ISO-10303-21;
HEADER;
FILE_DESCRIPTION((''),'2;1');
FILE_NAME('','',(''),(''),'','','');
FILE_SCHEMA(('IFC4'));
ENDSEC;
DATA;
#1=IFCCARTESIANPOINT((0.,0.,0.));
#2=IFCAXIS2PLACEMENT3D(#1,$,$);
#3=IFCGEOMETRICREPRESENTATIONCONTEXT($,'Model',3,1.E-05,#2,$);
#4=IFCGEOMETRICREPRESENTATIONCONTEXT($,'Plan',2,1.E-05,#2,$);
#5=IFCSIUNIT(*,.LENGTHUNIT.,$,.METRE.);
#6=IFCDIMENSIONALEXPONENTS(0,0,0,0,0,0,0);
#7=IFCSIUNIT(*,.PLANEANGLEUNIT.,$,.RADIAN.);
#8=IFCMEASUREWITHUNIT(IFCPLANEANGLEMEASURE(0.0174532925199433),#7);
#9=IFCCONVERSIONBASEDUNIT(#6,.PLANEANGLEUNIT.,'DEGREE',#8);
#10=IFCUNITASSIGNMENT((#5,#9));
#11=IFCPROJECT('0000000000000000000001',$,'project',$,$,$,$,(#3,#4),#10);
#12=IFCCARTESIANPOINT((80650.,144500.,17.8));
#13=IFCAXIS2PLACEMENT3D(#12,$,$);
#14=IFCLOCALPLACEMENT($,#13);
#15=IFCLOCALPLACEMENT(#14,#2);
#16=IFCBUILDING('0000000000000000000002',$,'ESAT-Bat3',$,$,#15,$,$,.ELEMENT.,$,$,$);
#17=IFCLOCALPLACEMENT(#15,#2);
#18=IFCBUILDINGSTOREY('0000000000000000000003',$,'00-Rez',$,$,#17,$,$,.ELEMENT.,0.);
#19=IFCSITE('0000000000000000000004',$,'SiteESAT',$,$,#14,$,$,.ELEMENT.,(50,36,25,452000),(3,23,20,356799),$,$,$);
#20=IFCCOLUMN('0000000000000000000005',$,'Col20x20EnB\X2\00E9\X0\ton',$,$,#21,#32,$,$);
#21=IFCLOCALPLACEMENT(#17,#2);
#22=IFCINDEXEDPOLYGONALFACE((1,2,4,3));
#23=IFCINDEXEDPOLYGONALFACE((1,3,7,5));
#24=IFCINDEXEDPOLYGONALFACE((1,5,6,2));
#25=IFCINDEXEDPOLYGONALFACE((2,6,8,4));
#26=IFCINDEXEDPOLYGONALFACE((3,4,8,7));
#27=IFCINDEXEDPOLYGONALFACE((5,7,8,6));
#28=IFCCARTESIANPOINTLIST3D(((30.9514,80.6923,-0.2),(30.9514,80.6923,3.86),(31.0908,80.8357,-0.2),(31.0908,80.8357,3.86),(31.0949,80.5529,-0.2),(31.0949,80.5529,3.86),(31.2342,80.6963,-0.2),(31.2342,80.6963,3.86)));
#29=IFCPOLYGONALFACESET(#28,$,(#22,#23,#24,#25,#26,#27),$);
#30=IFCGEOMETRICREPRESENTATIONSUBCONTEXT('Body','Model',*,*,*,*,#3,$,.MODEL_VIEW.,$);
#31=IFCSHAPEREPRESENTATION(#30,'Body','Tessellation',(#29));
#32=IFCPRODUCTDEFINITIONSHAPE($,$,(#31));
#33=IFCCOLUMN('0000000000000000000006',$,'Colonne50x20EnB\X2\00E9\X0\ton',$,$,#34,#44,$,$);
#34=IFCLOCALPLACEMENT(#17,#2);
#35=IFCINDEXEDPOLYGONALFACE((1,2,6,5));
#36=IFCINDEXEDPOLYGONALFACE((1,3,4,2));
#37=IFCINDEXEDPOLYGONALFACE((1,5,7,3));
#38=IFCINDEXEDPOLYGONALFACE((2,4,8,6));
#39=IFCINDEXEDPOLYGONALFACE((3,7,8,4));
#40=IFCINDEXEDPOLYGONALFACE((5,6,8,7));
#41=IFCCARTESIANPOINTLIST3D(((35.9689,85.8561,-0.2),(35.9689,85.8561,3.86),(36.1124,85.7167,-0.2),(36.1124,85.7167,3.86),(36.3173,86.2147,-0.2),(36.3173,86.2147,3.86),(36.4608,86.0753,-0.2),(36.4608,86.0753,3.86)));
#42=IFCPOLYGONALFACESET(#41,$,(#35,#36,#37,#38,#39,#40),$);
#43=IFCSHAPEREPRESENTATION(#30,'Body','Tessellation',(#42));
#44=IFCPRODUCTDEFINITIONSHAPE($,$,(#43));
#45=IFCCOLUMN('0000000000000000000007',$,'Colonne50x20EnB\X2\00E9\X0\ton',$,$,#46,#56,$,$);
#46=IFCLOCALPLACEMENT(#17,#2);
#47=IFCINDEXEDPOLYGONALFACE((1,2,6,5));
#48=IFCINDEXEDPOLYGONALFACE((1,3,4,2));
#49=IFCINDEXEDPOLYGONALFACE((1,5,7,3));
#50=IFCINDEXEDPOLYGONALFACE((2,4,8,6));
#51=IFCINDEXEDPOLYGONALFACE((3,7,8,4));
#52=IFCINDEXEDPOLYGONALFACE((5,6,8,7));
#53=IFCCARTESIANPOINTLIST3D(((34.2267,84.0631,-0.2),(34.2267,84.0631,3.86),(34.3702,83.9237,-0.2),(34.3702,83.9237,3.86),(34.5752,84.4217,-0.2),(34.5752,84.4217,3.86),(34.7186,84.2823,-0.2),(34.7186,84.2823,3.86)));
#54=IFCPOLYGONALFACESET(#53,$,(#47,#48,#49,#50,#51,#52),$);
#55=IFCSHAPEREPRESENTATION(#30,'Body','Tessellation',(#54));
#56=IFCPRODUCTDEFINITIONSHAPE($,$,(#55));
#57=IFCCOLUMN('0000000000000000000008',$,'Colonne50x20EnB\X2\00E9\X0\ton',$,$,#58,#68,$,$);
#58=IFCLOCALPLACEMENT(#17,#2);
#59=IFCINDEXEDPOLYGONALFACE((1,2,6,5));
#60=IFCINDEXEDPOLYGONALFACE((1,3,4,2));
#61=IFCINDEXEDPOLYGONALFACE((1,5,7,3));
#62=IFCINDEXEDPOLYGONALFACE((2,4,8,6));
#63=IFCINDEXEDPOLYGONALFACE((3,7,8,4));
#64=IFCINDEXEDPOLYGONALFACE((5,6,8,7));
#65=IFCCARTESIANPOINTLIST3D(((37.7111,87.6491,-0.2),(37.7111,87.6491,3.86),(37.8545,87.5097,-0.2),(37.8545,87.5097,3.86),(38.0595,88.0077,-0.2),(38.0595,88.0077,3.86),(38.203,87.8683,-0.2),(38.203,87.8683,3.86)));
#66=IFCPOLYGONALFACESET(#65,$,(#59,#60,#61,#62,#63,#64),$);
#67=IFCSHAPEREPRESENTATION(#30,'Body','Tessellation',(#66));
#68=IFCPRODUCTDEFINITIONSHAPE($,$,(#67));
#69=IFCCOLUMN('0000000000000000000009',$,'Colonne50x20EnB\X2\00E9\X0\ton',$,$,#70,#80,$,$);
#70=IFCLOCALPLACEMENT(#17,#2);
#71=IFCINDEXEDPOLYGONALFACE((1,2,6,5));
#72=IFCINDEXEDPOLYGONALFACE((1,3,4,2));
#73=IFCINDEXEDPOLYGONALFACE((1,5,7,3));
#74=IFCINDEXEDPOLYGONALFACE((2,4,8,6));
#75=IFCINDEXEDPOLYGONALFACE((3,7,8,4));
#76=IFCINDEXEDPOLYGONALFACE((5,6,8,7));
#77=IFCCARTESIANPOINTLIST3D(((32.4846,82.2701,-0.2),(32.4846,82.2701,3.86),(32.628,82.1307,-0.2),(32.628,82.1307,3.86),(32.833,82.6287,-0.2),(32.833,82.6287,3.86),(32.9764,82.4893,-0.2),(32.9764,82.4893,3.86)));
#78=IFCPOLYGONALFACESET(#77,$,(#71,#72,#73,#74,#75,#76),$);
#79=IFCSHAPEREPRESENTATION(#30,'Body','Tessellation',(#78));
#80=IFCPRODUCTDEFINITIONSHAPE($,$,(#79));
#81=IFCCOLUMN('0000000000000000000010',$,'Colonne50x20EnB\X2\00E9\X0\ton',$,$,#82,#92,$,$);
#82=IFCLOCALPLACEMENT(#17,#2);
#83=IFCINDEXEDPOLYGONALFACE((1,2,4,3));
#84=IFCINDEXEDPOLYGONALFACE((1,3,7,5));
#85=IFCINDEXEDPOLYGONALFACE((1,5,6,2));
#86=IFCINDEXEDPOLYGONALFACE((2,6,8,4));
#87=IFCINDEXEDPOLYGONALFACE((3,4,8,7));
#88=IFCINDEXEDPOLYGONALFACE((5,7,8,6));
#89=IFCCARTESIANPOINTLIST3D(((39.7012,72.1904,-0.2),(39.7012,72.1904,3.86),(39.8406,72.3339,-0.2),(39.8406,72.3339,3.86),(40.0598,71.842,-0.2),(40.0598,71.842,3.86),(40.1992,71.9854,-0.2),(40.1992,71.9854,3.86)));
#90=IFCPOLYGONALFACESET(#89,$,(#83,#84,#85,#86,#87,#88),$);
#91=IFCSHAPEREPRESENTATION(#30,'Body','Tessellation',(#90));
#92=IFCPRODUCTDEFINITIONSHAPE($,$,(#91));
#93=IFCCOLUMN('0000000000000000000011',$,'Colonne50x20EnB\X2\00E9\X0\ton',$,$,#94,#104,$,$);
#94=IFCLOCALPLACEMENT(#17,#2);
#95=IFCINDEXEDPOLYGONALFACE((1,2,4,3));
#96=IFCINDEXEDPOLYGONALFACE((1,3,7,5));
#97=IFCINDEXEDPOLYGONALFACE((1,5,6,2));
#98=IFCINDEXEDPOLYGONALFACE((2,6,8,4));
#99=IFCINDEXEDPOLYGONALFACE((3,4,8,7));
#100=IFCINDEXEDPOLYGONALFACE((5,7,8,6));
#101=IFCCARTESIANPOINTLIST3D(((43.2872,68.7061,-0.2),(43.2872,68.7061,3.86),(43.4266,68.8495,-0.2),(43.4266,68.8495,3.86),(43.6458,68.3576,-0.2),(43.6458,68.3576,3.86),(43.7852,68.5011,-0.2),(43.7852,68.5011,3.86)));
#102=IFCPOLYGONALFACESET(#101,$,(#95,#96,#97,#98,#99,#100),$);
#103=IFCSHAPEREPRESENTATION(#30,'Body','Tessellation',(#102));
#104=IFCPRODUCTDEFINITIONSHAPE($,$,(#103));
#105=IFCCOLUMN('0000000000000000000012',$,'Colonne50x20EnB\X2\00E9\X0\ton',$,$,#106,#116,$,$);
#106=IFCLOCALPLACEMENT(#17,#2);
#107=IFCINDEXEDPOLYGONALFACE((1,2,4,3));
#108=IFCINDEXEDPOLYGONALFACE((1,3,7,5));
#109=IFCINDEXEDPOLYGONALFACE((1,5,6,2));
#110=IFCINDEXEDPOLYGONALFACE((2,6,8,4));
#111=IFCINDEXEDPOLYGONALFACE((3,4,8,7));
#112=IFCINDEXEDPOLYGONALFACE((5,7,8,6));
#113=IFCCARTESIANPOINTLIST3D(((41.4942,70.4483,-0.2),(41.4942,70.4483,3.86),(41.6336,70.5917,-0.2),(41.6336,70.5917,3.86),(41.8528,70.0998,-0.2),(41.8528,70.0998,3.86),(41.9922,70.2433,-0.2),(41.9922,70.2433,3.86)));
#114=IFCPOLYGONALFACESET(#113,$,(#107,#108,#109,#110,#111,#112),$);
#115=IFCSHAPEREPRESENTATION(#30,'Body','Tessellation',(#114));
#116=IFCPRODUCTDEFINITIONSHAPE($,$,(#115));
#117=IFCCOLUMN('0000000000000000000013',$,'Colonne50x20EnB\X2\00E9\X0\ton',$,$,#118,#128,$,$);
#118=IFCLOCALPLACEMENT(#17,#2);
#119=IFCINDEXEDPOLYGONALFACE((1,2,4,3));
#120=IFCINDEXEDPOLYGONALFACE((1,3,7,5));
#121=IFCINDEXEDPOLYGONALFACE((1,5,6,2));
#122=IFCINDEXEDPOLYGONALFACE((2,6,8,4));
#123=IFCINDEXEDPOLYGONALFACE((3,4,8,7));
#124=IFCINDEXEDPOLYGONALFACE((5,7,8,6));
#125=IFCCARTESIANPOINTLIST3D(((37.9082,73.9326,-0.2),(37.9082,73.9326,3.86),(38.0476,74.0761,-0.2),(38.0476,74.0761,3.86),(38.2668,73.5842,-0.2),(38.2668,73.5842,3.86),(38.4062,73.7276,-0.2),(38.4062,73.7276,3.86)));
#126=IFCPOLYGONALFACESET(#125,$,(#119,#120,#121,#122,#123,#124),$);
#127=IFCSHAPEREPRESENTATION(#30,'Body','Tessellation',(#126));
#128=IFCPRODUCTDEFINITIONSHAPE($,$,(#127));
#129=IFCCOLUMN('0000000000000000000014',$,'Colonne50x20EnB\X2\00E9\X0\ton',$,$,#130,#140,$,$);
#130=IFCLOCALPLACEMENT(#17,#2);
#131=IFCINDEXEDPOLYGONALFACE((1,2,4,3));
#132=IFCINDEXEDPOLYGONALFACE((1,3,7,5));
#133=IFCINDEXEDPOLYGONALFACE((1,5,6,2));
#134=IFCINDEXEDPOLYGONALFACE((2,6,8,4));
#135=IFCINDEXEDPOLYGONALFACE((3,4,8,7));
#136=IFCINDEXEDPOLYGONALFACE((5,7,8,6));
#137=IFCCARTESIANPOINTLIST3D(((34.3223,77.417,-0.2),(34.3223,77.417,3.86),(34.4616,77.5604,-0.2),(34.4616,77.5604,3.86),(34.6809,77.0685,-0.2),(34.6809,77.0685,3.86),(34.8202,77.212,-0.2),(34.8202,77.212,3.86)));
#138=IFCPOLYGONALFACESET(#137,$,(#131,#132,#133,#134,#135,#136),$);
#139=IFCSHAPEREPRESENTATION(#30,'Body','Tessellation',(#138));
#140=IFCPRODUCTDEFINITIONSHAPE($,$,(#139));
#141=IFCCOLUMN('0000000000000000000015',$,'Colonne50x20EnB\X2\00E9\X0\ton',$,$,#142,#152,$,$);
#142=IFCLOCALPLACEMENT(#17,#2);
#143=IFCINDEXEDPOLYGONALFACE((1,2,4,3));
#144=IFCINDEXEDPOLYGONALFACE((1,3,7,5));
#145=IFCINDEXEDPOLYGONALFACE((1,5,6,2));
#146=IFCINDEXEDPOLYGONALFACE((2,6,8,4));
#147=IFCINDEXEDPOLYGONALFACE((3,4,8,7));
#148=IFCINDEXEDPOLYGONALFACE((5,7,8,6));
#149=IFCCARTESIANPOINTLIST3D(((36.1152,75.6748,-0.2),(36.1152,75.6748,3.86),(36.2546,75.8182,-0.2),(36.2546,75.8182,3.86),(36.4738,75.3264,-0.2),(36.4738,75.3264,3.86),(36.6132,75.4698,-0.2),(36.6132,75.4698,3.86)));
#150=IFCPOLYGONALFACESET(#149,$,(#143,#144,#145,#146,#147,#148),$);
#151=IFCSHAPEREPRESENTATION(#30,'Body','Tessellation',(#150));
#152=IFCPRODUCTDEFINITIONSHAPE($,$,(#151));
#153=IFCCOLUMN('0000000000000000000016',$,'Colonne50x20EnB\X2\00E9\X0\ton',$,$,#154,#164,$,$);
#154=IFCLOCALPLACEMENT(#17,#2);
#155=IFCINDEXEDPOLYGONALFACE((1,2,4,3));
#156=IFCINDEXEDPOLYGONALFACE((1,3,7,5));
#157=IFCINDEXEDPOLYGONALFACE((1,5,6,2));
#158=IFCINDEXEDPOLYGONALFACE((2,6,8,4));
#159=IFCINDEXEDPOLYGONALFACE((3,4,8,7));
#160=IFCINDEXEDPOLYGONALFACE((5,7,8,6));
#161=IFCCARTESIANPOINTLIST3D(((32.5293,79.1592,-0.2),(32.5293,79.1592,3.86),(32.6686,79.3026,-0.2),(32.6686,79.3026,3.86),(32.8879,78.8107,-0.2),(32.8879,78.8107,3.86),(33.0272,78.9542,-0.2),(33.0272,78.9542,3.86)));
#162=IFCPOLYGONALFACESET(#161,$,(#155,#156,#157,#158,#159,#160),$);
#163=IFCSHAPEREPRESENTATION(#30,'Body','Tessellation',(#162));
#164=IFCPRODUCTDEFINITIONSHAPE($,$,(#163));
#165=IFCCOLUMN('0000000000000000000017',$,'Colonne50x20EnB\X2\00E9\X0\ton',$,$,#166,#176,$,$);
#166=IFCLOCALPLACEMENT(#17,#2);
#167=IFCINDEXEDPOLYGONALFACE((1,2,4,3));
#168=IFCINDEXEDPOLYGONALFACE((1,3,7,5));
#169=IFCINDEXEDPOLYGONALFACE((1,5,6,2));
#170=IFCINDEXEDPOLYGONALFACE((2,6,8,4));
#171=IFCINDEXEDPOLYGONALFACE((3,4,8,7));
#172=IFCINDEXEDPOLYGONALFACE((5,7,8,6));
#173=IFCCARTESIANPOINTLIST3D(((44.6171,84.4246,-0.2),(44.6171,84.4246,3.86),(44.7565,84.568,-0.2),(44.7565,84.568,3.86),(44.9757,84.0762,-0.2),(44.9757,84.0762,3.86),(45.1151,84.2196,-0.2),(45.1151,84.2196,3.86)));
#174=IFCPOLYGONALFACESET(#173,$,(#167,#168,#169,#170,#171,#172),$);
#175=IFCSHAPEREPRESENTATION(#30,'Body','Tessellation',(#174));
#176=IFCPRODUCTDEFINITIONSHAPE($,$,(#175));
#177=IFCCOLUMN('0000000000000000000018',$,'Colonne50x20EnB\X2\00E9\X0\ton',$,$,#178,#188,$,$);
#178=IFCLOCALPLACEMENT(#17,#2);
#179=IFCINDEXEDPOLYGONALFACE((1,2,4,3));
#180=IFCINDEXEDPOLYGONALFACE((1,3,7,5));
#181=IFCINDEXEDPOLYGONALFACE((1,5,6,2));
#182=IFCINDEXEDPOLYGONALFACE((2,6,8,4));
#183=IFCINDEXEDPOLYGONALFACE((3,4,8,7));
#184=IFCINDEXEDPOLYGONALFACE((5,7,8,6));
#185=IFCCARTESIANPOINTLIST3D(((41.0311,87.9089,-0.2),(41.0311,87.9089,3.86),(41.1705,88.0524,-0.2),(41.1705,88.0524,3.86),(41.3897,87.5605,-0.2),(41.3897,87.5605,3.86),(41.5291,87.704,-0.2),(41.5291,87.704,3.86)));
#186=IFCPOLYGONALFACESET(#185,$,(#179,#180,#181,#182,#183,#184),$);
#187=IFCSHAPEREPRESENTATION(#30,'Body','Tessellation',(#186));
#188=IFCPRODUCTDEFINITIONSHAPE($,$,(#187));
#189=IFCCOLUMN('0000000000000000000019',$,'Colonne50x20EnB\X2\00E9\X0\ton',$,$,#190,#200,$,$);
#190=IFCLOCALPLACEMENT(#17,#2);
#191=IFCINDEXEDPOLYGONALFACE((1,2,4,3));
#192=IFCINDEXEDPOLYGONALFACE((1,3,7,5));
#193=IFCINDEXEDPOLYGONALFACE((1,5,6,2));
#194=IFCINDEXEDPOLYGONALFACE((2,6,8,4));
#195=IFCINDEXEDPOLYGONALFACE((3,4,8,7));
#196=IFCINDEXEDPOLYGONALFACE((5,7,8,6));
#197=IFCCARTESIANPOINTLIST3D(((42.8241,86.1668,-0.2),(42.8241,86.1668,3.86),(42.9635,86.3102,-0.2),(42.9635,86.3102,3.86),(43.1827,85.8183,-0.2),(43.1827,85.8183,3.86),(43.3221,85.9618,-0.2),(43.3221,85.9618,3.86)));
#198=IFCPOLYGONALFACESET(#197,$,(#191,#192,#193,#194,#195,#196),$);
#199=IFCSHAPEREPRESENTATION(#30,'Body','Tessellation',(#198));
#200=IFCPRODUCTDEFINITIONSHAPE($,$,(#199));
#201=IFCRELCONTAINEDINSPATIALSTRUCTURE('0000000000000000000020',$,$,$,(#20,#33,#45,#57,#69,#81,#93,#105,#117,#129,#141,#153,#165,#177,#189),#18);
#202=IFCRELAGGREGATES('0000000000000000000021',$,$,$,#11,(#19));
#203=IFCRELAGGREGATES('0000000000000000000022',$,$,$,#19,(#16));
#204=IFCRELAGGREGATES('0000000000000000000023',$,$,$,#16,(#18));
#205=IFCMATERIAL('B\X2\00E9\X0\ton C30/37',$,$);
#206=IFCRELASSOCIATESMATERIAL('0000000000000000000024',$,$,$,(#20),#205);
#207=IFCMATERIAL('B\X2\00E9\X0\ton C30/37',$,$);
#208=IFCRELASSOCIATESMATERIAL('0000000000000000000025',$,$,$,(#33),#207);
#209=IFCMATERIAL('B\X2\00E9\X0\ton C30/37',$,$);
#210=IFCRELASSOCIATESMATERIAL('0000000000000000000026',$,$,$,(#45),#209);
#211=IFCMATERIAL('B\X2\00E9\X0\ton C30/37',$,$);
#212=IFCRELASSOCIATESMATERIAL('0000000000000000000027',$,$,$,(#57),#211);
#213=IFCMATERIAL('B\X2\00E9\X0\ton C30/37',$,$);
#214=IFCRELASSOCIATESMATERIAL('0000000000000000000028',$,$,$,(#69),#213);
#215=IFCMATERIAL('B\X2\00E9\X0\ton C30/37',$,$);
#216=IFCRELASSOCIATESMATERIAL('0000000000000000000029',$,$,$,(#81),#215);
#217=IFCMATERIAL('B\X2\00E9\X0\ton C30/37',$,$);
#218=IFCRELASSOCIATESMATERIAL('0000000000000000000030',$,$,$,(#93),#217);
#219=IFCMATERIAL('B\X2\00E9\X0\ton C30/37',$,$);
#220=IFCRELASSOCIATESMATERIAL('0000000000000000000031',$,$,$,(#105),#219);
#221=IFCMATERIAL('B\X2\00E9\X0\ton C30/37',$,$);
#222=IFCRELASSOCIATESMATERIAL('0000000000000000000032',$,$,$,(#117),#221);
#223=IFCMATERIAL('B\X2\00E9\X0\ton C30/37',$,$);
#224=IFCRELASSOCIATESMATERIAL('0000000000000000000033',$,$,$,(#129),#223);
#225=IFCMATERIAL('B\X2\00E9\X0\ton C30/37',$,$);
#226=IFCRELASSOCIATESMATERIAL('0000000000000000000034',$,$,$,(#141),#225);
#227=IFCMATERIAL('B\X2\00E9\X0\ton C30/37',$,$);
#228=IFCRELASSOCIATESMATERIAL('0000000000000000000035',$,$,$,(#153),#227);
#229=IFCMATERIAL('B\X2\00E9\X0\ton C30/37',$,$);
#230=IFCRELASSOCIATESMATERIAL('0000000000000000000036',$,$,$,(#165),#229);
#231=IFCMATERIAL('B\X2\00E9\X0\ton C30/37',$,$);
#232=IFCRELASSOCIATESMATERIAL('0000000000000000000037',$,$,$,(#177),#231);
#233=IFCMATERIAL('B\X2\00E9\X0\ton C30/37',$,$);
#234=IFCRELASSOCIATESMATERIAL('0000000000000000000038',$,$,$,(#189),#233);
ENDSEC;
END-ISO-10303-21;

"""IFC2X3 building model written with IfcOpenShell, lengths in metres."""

from ifc_helpers import new_model, entity, si_unit, converted_unit, frame, frame_2d, origin, origin_with_axes, place, context, subcontext, project, spatial, rectangle, extrude, material, element, save


model = new_model("IFC2X3")

# Units and contexts
model_context = context("Model", 3, precision=1e-05, world=origin())
plan_context = context("Plan", 2, precision=1e-05, world=origin())
body_context = subcontext(model_context, "Body", "Model", "MODEL_VIEW")
ifc_project = project(units=[si_unit("LENGTHUNIT", "METRE"), converted_unit("PLANEANGLEUNIT", "DEGREE", entity("IfcPlaneAngleMeasure", 0.0174532925199433), si_unit("PLANEANGLEUNIT", "RADIAN"), dimensions=[0, 0, 0, 0, 0, 0, 0])], contexts=[model_context, plan_context])

# Site, building, storey
site_placement = place(None, frame((80650.0, 144500.0, 17.8)))
site = spatial("IfcSite", under=ifc_project, at=site_placement, Name="SiteESAT", CompositionType="ELEMENT", RefLatitude=(50, 36, 25, 452000), RefLongitude=(3, 23, 20, 356799))
building_placement = place(site_placement, origin())
building = spatial("IfcBuilding", under=site, at=building_placement, Name="ESAT-Bat3", CompositionType="ELEMENT")
storey_placement = place(building_placement, origin())
storey = spatial("IfcBuildingStorey", under=building, at=storey_placement, Name="00-Rez", CompositionType="ELEMENT", Elevation=0.0)

# Columns
ifc_material_1 = material(Name="Béton C30/37")
column_1_placement = place(storey_placement, frame((31.0949, 80.5529, -0.2)))
element("IfcColumn", 1, at=column_1_placement, inside=storey, material=ifc_material_1, Name="Col20x20EnBéton", context=body_context, shape_type="SweptSolid", body=[
    extrude(rectangle(XDim=0.2, YDim=0.2, at=frame_2d((-0.002, 0.1414), x_axis=(0.696872, 0.717196))), origin_with_axes(), (0.0, 0.0, 1.0), 4.06),
])
ifc_material_2 = material(Name="Béton C30/37")
column_2_placement = place(storey_placement, frame((36.1124, 85.7167, -0.2)))
element("IfcColumn", 2, at=column_2_placement, inside=storey, material=ifc_material_2, Name="Colonne50x20EnBéton", context=body_context, shape_type="SweptSolid", body=[
    extrude(rectangle(XDim=0.5, YDim=0.2, at=frame_2d((0.1025, 0.249), x_axis=(0.696872, 0.717196))), origin_with_axes(), (0.0, 0.0, 1.0), 4.06),
])
ifc_material_3 = material(Name="Béton C30/37")
column_3_placement = place(storey_placement, frame((34.3702, 83.9237, -0.2)))
element("IfcColumn", 3, at=column_3_placement, inside=storey, material=ifc_material_3, Name="Colonne50x20EnBéton", context=body_context, shape_type="SweptSolid", body=[
    extrude(rectangle(XDim=0.5, YDim=0.2, at=frame_2d((0.1025, 0.249), x_axis=(0.696872, 0.717196))), origin_with_axes(), (0.0, 0.0, 1.0), 4.06),
])
ifc_material_4 = material(Name="Béton C30/37")
column_4_placement = place(storey_placement, frame((37.8545, 87.5097, -0.2)))
element("IfcColumn", 4, at=column_4_placement, inside=storey, material=ifc_material_4, Name="Colonne50x20EnBéton", context=body_context, shape_type="SweptSolid", body=[
    extrude(rectangle(XDim=0.5, YDim=0.2, at=frame_2d((0.1025, 0.249), x_axis=(0.696872, 0.717196))), origin_with_axes(), (0.0, 0.0, 1.0), 4.06),
])
ifc_material_5 = material(Name="Béton C30/37")
column_5_placement = place(storey_placement, frame((32.628, 82.1307, -0.2)))
element("IfcColumn", 5, at=column_5_placement, inside=storey, material=ifc_material_5, Name="Colonne50x20EnBéton", context=body_context, shape_type="SweptSolid", body=[
    extrude(rectangle(XDim=0.5, YDim=0.2, at=frame_2d((0.1025, 0.249), x_axis=(0.696872, 0.717196))), origin_with_axes(), (0.0, 0.0, 1.0), 4.06),
])
ifc_material_6 = material(Name="Béton C30/37")
column_6_placement = place(storey_placement, frame((40.1992, 71.9854, -0.2)))
element("IfcColumn", 6, at=column_6_placement, inside=storey, material=ifc_material_6, Name="Colonne50x20EnBéton", context=body_context, shape_type="SweptSolid", body=[
    extrude(rectangle(XDim=0.5, YDim=0.2, at=frame_2d((-0.249, 0.1025), x_axis=(-0.717196, 0.696872))), origin_with_axes(), (0.0, 0.0, 1.0), 4.06),
])
ifc_material_7 = material(Name="Béton C30/37")
column_7_placement = place(storey_placement, frame((43.7852, 68.5011, -0.2)))
element("IfcColumn", 7, at=column_7_placement, inside=storey, material=ifc_material_7, Name="Colonne50x20EnBéton", context=body_context, shape_type="SweptSolid", body=[
    extrude(rectangle(XDim=0.5, YDim=0.2, at=frame_2d((-0.249, 0.1025), x_axis=(-0.717196, 0.696872))), origin_with_axes(), (0.0, 0.0, 1.0), 4.06),
])
ifc_material_8 = material(Name="Béton C30/37")
column_8_placement = place(storey_placement, frame((41.9922, 70.2433, -0.2)))
element("IfcColumn", 8, at=column_8_placement, inside=storey, material=ifc_material_8, Name="Colonne50x20EnBéton", context=body_context, shape_type="SweptSolid", body=[
    extrude(rectangle(XDim=0.5, YDim=0.2, at=frame_2d((-0.249, 0.1025), x_axis=(-0.717196, 0.696872))), origin_with_axes(), (0.0, 0.0, 1.0), 4.06),
])
ifc_material_9 = material(Name="Béton C30/37")
column_9_placement = place(storey_placement, frame((38.4062, 73.7276, -0.2)))
element("IfcColumn", 9, at=column_9_placement, inside=storey, material=ifc_material_9, Name="Colonne50x20EnBéton", context=body_context, shape_type="SweptSolid", body=[
    extrude(rectangle(XDim=0.5, YDim=0.2, at=frame_2d((-0.249, 0.1025), x_axis=(-0.717196, 0.696872))), origin_with_axes(), (0.0, 0.0, 1.0), 4.06),
])
ifc_material_10 = material(Name="Béton C30/37")
column_10_placement = place(storey_placement, frame((34.8202, 77.212, -0.2)))
element("IfcColumn", 10, at=column_10_placement, inside=storey, material=ifc_material_10, Name="Colonne50x20EnBéton", context=body_context, shape_type="SweptSolid", body=[
    extrude(rectangle(XDim=0.5, YDim=0.2, at=frame_2d((-0.249, 0.1025), x_axis=(-0.717196, 0.696872))), origin_with_axes(), (0.0, 0.0, 1.0), 4.06),
])
ifc_material_11 = material(Name="Béton C30/37")
column_11_placement = place(storey_placement, frame((36.6132, 75.4698, -0.2)))
element("IfcColumn", 11, at=column_11_placement, inside=storey, material=ifc_material_11, Name="Colonne50x20EnBéton", context=body_context, shape_type="SweptSolid", body=[
    extrude(rectangle(XDim=0.5, YDim=0.2, at=frame_2d((-0.249, 0.1025), x_axis=(-0.717196, 0.696872))), origin_with_axes(), (0.0, 0.0, 1.0), 4.06),
])
ifc_material_12 = material(Name="Béton C30/37")
column_12_placement = place(storey_placement, frame((33.0272, 78.9542, -0.2)))
element("IfcColumn", 12, at=column_12_placement, inside=storey, material=ifc_material_12, Name="Colonne50x20EnBéton", context=body_context, shape_type="SweptSolid", body=[
    extrude(rectangle(XDim=0.5, YDim=0.2, at=frame_2d((-0.249, 0.1025), x_axis=(-0.717196, 0.696872))), origin_with_axes(), (0.0, 0.0, 1.0), 4.06),
])
ifc_material_13 = material(Name="Béton C30/37")
column_13_placement = place(storey_placement, frame((45.1151, 84.2196, -0.2)))
element("IfcColumn", 13, at=column_13_placement, inside=storey, material=ifc_material_13, Name="Colonne50x20EnBéton", context=body_context, shape_type="SweptSolid", body=[
    extrude(rectangle(XDim=0.5, YDim=0.2, at=frame_2d((-0.249, 0.1025), x_axis=(-0.717196, 0.696872))), origin_with_axes(), (0.0, 0.0, 1.0), 4.06),
])
ifc_material_14 = material(Name="Béton C30/37")
column_14_placement = place(storey_placement, frame((41.5291, 87.704, -0.2)))
element("IfcColumn", 14, at=column_14_placement, inside=storey, material=ifc_material_14, Name="Colonne50x20EnBéton", context=body_context, shape_type="SweptSolid", body=[
    extrude(rectangle(XDim=0.5, YDim=0.2, at=frame_2d((-0.249, 0.1025), x_axis=(-0.717196, 0.696872))), origin_with_axes(), (0.0, 0.0, 1.0), 4.06),
])
ifc_material_15 = material(Name="Béton C30/37")
column_15_placement = place(storey_placement, frame((43.3221, 85.9618, -0.2)))
element("IfcColumn", 15, at=column_15_placement, inside=storey, material=ifc_material_15, Name="Colonne50x20EnBéton", context=body_context, shape_type="SweptSolid", body=[
    extrude(rectangle(XDim=0.5, YDim=0.2, at=frame_2d((-0.249, 0.1025), x_axis=(-0.717196, 0.696872))), origin_with_axes(), (0.0, 0.0, 1.0), 4.06),
])

save(model, "model.ifc")
